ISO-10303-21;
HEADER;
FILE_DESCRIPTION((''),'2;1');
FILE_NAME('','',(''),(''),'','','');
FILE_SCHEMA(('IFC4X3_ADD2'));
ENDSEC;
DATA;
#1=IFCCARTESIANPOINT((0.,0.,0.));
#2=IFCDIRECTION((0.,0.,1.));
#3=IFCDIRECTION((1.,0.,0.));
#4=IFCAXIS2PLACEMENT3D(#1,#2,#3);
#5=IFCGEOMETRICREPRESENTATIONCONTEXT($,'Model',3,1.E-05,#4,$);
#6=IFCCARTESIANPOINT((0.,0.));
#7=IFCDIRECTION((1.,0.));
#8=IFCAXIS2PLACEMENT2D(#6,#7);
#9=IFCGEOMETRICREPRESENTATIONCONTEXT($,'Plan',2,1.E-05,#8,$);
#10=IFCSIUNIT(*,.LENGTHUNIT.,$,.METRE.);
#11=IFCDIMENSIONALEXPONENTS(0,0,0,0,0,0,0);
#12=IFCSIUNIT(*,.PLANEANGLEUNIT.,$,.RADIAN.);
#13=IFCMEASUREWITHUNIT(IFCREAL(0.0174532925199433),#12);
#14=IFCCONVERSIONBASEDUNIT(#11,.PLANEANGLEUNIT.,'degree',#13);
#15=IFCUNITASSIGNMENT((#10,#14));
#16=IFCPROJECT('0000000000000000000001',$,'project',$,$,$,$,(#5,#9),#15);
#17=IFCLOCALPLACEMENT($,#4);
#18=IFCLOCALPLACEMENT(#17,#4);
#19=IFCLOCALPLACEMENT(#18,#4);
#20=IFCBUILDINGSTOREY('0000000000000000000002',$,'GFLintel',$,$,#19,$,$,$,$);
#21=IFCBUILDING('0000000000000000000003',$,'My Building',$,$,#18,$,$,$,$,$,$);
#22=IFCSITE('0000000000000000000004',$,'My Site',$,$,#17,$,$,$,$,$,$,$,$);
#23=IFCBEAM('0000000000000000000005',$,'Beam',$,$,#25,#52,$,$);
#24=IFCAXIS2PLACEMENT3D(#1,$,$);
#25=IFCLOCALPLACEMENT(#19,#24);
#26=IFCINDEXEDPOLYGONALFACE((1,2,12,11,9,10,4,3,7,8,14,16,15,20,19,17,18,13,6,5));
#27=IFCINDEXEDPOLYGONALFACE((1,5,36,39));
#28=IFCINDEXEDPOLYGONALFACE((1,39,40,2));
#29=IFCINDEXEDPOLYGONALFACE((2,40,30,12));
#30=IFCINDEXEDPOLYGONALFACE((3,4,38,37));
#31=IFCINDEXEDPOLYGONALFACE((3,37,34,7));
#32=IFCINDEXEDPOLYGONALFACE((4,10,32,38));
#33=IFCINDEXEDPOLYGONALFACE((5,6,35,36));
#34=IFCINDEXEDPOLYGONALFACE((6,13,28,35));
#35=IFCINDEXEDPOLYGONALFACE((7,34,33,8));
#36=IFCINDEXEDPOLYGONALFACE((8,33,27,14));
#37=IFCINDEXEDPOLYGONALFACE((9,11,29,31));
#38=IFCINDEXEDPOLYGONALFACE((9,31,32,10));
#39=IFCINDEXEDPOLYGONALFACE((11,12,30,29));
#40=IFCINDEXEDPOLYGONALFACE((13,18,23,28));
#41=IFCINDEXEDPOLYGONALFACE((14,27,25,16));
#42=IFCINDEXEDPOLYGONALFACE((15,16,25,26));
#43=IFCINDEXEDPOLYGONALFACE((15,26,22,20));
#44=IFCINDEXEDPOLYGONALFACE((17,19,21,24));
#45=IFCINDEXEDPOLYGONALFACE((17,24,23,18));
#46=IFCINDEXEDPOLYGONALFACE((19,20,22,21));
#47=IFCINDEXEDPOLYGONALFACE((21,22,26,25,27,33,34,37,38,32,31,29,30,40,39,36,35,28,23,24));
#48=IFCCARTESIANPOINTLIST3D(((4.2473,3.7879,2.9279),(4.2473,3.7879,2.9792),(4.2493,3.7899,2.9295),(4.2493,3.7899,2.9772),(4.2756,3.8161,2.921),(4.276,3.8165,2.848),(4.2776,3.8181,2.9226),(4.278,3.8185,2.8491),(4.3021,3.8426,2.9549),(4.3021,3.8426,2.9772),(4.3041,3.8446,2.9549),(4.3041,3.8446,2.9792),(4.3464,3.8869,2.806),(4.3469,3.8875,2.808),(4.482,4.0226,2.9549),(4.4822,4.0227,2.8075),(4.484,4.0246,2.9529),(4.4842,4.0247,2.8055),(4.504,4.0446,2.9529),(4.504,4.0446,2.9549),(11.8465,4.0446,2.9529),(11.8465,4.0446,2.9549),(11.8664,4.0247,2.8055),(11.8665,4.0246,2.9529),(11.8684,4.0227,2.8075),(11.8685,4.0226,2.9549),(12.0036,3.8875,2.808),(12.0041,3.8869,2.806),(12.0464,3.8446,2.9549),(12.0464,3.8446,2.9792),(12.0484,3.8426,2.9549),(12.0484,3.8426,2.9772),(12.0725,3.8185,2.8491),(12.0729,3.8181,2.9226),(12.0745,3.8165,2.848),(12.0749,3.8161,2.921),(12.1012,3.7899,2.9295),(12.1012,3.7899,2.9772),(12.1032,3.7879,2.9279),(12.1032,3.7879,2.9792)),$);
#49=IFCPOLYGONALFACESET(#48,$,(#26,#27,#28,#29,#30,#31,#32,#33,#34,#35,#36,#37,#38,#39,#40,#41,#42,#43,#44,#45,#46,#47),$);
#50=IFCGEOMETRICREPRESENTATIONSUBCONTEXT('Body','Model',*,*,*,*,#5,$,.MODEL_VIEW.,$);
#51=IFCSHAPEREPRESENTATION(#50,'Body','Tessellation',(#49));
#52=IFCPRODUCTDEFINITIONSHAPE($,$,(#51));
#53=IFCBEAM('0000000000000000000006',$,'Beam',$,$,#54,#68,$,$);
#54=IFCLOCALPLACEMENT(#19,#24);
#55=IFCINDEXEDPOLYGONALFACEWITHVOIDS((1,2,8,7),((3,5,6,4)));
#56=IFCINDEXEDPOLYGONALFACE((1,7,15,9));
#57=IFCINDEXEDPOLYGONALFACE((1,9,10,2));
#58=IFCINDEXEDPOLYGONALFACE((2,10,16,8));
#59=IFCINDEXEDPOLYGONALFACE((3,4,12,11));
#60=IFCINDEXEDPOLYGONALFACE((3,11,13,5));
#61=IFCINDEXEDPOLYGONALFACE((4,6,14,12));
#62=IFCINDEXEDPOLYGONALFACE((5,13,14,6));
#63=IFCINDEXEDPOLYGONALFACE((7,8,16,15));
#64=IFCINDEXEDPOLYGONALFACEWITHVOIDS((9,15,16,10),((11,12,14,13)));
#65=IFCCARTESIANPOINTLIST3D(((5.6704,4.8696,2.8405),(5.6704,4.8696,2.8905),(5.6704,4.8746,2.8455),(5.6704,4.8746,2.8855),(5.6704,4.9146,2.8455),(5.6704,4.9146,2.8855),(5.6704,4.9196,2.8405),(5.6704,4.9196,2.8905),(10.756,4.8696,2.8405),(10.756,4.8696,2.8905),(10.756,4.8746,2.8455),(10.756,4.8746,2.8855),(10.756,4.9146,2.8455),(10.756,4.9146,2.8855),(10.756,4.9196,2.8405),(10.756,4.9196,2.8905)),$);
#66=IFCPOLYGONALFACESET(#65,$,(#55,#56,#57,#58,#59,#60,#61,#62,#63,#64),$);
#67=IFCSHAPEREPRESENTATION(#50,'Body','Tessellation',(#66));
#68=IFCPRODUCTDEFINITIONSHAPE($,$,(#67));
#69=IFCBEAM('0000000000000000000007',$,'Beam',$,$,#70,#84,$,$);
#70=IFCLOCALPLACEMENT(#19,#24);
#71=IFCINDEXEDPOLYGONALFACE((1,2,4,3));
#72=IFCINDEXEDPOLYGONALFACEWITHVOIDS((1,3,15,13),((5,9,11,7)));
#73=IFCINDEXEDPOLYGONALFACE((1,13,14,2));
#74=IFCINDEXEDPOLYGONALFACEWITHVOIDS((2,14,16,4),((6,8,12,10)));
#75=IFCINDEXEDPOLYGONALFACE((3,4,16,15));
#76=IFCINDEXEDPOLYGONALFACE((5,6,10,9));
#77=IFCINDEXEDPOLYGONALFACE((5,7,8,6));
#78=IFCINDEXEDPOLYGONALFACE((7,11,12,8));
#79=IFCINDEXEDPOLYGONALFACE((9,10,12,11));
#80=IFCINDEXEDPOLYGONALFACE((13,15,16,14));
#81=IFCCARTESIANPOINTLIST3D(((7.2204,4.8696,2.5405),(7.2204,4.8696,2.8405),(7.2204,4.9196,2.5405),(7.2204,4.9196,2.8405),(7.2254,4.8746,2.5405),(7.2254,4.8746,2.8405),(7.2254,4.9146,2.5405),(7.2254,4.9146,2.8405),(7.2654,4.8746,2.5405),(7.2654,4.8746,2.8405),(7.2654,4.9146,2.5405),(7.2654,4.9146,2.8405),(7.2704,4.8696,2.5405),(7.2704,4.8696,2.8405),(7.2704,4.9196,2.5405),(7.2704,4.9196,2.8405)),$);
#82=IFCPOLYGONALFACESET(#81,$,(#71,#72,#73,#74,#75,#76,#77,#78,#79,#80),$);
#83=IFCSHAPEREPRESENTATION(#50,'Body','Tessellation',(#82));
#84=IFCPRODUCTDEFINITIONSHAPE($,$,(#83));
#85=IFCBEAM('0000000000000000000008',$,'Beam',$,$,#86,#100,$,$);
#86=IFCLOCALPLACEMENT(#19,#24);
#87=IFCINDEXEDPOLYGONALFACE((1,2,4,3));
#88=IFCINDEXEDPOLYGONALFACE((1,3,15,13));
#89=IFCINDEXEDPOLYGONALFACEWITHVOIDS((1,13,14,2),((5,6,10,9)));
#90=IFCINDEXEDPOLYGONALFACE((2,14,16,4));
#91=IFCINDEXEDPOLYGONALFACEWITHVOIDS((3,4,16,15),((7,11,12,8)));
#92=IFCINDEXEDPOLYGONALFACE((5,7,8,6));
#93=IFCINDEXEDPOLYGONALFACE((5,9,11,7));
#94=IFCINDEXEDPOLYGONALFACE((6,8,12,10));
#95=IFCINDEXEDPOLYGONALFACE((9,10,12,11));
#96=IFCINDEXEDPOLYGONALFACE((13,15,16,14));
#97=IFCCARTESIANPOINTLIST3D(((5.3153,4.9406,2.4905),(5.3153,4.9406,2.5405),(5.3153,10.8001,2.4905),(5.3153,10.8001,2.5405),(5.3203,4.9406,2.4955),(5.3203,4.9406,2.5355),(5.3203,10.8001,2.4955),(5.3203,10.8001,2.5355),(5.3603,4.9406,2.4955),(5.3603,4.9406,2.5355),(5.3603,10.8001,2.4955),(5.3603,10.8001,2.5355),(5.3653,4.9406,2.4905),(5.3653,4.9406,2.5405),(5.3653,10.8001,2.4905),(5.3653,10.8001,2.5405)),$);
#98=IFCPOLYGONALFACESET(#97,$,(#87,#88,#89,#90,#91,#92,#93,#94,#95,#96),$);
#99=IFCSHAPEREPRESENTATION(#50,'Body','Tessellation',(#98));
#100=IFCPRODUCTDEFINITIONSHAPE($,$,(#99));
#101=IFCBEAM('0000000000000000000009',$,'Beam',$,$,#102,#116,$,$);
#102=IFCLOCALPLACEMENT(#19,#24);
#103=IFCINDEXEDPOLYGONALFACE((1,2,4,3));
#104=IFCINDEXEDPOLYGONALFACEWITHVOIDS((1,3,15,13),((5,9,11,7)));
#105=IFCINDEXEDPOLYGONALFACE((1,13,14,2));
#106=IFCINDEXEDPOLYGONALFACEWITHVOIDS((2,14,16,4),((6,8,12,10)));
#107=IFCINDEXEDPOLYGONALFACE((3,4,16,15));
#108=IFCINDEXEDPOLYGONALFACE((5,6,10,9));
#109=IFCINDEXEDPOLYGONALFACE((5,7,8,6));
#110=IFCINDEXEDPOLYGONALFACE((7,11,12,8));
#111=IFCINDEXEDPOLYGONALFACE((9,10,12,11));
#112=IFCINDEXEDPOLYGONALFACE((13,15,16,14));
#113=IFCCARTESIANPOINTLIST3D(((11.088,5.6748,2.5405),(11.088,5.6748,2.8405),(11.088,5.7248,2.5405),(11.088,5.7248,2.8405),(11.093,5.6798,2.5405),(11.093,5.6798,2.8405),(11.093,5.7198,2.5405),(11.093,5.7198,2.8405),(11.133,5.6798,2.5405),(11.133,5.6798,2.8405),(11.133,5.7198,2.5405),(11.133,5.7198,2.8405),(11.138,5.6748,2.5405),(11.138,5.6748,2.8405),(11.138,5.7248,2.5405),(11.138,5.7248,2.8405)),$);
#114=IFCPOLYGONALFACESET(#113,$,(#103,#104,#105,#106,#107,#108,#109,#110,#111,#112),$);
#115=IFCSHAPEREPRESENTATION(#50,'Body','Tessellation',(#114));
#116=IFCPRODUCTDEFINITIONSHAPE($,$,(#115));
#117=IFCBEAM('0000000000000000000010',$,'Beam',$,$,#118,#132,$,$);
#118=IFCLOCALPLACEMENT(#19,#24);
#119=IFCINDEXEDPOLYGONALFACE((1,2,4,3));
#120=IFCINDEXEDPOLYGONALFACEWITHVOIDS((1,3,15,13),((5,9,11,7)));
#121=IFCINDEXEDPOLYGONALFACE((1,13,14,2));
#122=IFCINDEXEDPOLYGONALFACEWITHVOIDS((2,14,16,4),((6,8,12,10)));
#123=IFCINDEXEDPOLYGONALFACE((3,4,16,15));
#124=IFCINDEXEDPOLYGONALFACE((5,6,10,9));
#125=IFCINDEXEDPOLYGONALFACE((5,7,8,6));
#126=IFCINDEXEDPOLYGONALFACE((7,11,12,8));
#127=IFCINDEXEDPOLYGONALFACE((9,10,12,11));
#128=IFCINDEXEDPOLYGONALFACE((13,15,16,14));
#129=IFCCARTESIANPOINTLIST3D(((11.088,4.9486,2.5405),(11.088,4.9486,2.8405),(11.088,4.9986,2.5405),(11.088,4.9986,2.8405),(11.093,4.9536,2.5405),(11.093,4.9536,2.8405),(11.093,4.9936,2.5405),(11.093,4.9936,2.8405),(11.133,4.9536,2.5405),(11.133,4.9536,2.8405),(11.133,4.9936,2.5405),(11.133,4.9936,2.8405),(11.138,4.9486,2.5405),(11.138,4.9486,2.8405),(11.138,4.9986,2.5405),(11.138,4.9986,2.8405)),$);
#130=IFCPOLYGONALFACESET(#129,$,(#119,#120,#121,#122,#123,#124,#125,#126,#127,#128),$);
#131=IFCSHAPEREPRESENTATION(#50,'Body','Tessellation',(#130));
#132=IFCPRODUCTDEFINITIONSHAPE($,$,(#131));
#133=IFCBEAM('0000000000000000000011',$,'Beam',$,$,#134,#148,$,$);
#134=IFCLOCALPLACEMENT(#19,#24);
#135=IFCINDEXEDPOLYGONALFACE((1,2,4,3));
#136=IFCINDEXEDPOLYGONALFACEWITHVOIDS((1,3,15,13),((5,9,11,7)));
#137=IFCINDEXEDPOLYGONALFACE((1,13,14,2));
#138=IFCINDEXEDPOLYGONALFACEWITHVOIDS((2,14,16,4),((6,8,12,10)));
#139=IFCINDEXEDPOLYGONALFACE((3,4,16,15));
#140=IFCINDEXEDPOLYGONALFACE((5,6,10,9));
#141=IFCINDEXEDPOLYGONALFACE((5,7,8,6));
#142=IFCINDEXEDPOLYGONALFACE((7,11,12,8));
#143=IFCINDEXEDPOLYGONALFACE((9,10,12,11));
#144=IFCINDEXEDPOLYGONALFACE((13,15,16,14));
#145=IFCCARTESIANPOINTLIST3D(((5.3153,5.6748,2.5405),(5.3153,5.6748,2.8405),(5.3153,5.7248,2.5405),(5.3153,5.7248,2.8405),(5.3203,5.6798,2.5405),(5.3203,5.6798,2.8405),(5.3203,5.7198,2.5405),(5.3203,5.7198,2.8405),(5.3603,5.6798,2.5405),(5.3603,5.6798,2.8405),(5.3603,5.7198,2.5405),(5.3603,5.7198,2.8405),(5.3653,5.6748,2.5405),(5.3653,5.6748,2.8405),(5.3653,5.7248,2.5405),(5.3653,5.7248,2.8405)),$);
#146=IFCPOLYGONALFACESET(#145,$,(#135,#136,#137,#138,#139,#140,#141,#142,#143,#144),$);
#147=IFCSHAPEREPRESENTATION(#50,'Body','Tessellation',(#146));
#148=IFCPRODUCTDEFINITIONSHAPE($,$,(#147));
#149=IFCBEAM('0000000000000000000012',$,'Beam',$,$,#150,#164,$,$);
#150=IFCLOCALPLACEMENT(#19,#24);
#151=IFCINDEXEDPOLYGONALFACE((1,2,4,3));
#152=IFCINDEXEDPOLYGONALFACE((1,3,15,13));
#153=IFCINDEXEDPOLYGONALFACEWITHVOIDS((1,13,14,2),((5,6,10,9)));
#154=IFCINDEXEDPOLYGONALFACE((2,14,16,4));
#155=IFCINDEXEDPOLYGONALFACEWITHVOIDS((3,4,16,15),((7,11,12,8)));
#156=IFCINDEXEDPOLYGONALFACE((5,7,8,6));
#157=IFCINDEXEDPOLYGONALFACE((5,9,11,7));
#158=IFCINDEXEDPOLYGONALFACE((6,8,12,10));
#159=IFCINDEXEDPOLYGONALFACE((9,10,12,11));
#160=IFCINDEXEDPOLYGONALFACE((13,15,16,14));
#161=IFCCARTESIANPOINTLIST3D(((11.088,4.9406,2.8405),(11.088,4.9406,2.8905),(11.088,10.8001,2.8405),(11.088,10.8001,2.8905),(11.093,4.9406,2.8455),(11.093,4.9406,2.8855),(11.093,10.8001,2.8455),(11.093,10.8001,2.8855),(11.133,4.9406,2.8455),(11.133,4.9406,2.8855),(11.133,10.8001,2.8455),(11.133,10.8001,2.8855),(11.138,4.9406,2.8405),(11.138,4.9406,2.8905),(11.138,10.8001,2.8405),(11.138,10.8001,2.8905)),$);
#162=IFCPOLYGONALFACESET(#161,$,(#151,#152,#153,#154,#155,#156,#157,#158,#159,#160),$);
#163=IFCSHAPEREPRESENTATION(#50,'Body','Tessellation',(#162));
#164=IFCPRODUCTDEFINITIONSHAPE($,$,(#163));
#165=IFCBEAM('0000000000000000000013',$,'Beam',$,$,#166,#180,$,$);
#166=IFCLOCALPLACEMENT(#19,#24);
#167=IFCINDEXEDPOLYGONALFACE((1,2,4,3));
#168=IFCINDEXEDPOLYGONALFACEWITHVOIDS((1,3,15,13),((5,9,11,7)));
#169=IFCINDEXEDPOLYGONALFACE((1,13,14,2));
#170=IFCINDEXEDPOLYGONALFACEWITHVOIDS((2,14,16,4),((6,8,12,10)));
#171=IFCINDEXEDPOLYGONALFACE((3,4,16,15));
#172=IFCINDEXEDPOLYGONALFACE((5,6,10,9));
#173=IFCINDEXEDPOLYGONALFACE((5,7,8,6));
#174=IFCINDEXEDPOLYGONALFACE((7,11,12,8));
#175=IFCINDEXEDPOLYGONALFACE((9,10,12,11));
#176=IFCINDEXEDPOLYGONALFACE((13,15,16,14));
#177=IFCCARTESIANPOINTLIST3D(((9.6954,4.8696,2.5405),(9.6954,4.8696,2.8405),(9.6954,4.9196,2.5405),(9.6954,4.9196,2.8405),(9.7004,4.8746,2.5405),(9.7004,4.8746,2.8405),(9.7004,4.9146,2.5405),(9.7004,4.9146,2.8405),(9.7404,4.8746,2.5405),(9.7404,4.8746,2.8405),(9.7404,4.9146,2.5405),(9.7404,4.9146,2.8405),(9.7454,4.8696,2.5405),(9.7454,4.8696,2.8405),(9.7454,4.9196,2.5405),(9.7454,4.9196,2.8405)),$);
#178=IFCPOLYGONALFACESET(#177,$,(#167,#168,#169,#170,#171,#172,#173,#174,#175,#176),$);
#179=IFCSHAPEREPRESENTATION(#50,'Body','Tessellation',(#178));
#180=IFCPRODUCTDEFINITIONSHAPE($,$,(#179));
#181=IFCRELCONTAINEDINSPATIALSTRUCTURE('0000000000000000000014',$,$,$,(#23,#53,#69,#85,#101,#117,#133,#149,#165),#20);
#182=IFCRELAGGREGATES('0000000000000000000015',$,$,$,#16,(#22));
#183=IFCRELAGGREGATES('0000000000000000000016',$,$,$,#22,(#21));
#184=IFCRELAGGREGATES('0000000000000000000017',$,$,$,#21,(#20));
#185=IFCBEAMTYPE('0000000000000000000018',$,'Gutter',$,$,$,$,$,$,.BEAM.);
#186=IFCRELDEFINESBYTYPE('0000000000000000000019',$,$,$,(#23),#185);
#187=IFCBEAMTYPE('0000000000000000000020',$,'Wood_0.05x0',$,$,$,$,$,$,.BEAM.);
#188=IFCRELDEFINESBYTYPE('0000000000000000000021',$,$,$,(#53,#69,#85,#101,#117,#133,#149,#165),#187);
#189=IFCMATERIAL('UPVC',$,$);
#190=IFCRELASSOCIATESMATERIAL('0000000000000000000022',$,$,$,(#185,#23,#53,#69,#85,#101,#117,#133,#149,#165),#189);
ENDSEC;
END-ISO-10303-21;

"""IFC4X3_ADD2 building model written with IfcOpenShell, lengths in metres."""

from ifc_helpers import new_model, entity, si_unit, converted_unit, frame, origin_with_axes, origin_2d_with_axis, place, context, subcontext, project, spatial, indexed_curve, hollow_rectangle, outline, extrude, clip, halfspace, material, material_profile, profile_set, profile_usage, type_object, element, save


model = new_model("IFC4X3_ADD2")

# Units and contexts
model_context = context("Model", 3, precision=1e-05, world=origin_with_axes())
plan_context = context("Plan", 2, precision=1e-05, world=origin_2d_with_axis())
body_context = subcontext(model_context, "Body", "Model", "MODEL_VIEW")
ifc_project = project(units=[si_unit("LENGTHUNIT", "METRE"), converted_unit("PLANEANGLEUNIT", "degree", entity("IfcReal", 0.0174532925199433), si_unit("PLANEANGLEUNIT", "RADIAN"), dimensions=[0, 0, 0, 0, 0, 0, 0])], contexts=[model_context, plan_context])

# Site, building, storey
site_placement = place(None, origin_with_axes())
site = spatial("IfcSite", under=ifc_project, at=site_placement, Name="My Site")
building_placement = place(site_placement, origin_with_axes())
building = spatial("IfcBuilding", under=site, at=building_placement, Name="My Building")
storey_placement = place(building_placement, origin_with_axes())
storey = spatial("IfcBuildingStorey", under=building, at=storey_placement, Name="GFLintel")

# Beams
ifc_material_1 = material(Name="UPVC")
ifc_material_profile_1 = material_profile(ifc_material_1, outline(indexed_curve([(0.0548, 0.1717), (0.002, 0.1717), (0.002, 0.124), (0.0303, 0.1171), (0.0307, 0.0436), (0.0996, 0.0025), (0.2349, 0.002), (0.2347, 0.1494), (0.2567, 0.1494), (0.2567, 0.1474), (0.2367, 0.1474), (0.2369, 0.0), (0.0991, 0.0005), (0.0287, 0.0425), (0.0283, 0.1155), (0.0, 0.1224), (0.0, 0.1737), (0.0568, 0.1737), (0.0568, 0.1494), (0.0548, 0.1494), (0.0548, 0.1717)])))
ifc_profile_set_1 = profile_set([ifc_material_profile_1])
ifc_profile_usage_1 = profile_usage(ifc_profile_set_1, cardinal=5)
ifc_material_profile_2 = material_profile(ifc_material_1, outline(indexed_curve([(0.0548, 0.1717), (0.002, 0.1717), (0.002, 0.124), (0.0303, 0.1171), (0.0307, 0.0436), (0.0996, 0.0025), (0.2349, 0.002), (0.2347, 0.1494), (0.2567, 0.1494), (0.2567, 0.1474), (0.2367, 0.1474), (0.2369, 0.0), (0.0991, 0.0005), (0.0287, 0.0425), (0.0283, 0.1155), (0.0, 0.1224), (0.0, 0.1737), (0.0568, 0.1737), (0.0568, 0.1494), (0.0548, 0.1494), (0.0548, 0.1717)])))
ifc_profile_set_2 = profile_set([ifc_material_profile_2])
beam_type_1 = type_object("IfcBeamType", Name="Gutter", PredefinedType="BEAM", material=ifc_profile_set_2)
beam_1_placement = place(storey_placement, frame((4.2473, 3.7879, 2.8055), z_axis=(1.0, 0.0, 0.0), x_axis=(0.0, 1.0, 0.0)))
element("IfcBeam", 1, at=beam_1_placement, inside=storey, type_object=beam_type_1, material=ifc_profile_usage_1, Name="Beam", context=body_context, shape_type="Clipping", body=[
    clip(clip(extrude(outline(indexed_curve([(0.0548, 0.1717), (0.002, 0.1717), (0.002, 0.124), (0.0303, 0.1171), (0.0307, 0.0436), (0.0996, 0.0025), (0.2349, 0.002), (0.2347, 0.1494), (0.2567, 0.1494), (0.2567, 0.1474), (0.2367, 0.1474), (0.2369, 0.0), (0.0991, 0.0005), (0.0287, 0.0425), (0.0283, 0.1155), (0.0, 0.1224), (0.0, 0.1737), (0.0568, 0.1737), (0.0568, 0.1494), (0.0548, 0.1494), (0.0548, 0.1717)])), origin_with_axes(), (0.0, 0.0, 1.0), 7.8559), halfspace(frame((0.0, -2.8055, 7.8559), z_axis=(0.707108, 0.0, 0.707106), x_axis=(0.0, -1.0, 0.0)), False)), halfspace(frame((0.0, -2.8055, 0.0), z_axis=(0.707106, 0.0, -0.707107), x_axis=(0.0, -1.0, 0.0)), False)),
])
ifc_material_profile_3 = material_profile(ifc_material_1, hollow_rectangle(XDim=0.05, YDim=0.05, WallThickness=0.005))
ifc_profile_set_3 = profile_set([ifc_material_profile_3])
ifc_profile_usage_2 = profile_usage(ifc_profile_set_3)
beam_type_2 = type_object("IfcBeamType", Name="Wood_0.05x0", PredefinedType="BEAM")
beam_2_placement = place(storey_placement, frame((5.6704, 4.8946, 2.8655), z_axis=(1.0, 0.0, 0.000001), x_axis=(0.0, 1.0, 0.0)))
element("IfcBeam", 2, at=beam_2_placement, inside=storey, type_object=beam_type_2, material=ifc_profile_usage_2, Name="Beam", context=body_context, shape_type="SweptSolid", body=[
    extrude(hollow_rectangle(XDim=0.05, YDim=0.05, WallThickness=0.005), origin_with_axes(), (0.0, 0.0, 1.0), 5.0856),
])
ifc_profile_usage_3 = profile_usage(ifc_profile_set_3, cardinal=5)
beam_3_placement = place(storey_placement, frame((7.2454, 4.8946, 2.5405), z_axis=(-0.000001, 0.0, 1.0), x_axis=(0.0, 1.0, 0.0)))
element("IfcBeam", 3, at=beam_3_placement, inside=storey, type_object=beam_type_2, material=ifc_profile_usage_3, Name="Beam", context=body_context, shape_type="SweptSolid", body=[
    extrude(hollow_rectangle(XDim=0.05, YDim=0.05, WallThickness=0.005), origin_with_axes(), (0.0, 0.0, 1.0), 0.3),
])
ifc_profile_usage_4 = profile_usage(ifc_profile_set_3, cardinal=5)
beam_4_placement = place(storey_placement, frame((5.3403, 4.9406, 2.5155), z_axis=(0.0, 1.0, 0.000001), x_axis=(-1.0, 0.0, 0.0)))
element("IfcBeam", 4, at=beam_4_placement, inside=storey, type_object=beam_type_2, material=ifc_profile_usage_4, Name="Beam", context=body_context, shape_type="SweptSolid", body=[
    extrude(hollow_rectangle(XDim=0.05, YDim=0.05, WallThickness=0.005), origin_with_axes(), (0.0, 0.0, 1.0), 5.8595),
])
ifc_profile_usage_5 = profile_usage(ifc_profile_set_3, cardinal=5)
beam_5_placement = place(storey_placement, frame((11.113, 5.6998, 2.5405), z_axis=(0.0, -0.000001, 1.0), x_axis=(-1.0, 0.0, 0.0)))
element("IfcBeam", 5, at=beam_5_placement, inside=storey, type_object=beam_type_2, material=ifc_profile_usage_5, Name="Beam", context=body_context, shape_type="SweptSolid", body=[
    extrude(hollow_rectangle(XDim=0.05, YDim=0.05, WallThickness=0.005), origin_with_axes(), (0.0, 0.0, 1.0), 0.3),
])
ifc_profile_usage_6 = profile_usage(ifc_profile_set_3, cardinal=5)
beam_6_placement = place(storey_placement, frame((11.113, 4.9736, 2.5405), z_axis=(0.0, -0.000001, 1.0), x_axis=(-1.0, 0.0, 0.0)))
element("IfcBeam", 6, at=beam_6_placement, inside=storey, type_object=beam_type_2, material=ifc_profile_usage_6, Name="Beam", context=body_context, shape_type="SweptSolid", body=[
    extrude(hollow_rectangle(XDim=0.05, YDim=0.05, WallThickness=0.005), origin_with_axes(), (0.0, 0.0, 1.0), 0.3),
])
ifc_profile_usage_7 = profile_usage(ifc_profile_set_3, cardinal=5)
beam_7_placement = place(storey_placement, frame((5.3403, 5.6998, 2.5405), z_axis=(0.0, -0.000001, 1.0), x_axis=(-1.0, 0.0, 0.0)))
element("IfcBeam", 7, at=beam_7_placement, inside=storey, type_object=beam_type_2, material=ifc_profile_usage_7, Name="Beam", context=body_context, shape_type="SweptSolid", body=[
    extrude(hollow_rectangle(XDim=0.05, YDim=0.05, WallThickness=0.005), origin_with_axes(), (0.0, 0.0, 1.0), 0.3),
])
ifc_profile_usage_8 = profile_usage(ifc_profile_set_3, cardinal=5)
beam_8_placement = place(storey_placement, frame((11.113, 4.9406, 2.8655), z_axis=(0.0, 1.0, 0.000001), x_axis=(-1.0, 0.0, 0.0)))
element("IfcBeam", 8, at=beam_8_placement, inside=storey, type_object=beam_type_2, material=ifc_profile_usage_8, Name="Beam", context=body_context, shape_type="SweptSolid", body=[
    extrude(hollow_rectangle(XDim=0.05, YDim=0.05, WallThickness=0.005), origin_with_axes(), (0.0, 0.0, 1.0), 5.8595),
])
ifc_profile_usage_9 = profile_usage(ifc_profile_set_3, cardinal=5)
beam_9_placement = place(storey_placement, frame((9.7204, 4.8946, 2.5405), z_axis=(-0.000001, 0.0, 1.0), x_axis=(0.0, 1.0, 0.0)))
element("IfcBeam", 9, at=beam_9_placement, inside=storey, type_object=beam_type_2, material=ifc_profile_usage_9, Name="Beam", context=body_context, shape_type="SweptSolid", body=[
    extrude(hollow_rectangle(XDim=0.05, YDim=0.05, WallThickness=0.005), origin_with_axes(), (0.0, 0.0, 1.0), 0.3),
])

save(model, "model.ifc")
